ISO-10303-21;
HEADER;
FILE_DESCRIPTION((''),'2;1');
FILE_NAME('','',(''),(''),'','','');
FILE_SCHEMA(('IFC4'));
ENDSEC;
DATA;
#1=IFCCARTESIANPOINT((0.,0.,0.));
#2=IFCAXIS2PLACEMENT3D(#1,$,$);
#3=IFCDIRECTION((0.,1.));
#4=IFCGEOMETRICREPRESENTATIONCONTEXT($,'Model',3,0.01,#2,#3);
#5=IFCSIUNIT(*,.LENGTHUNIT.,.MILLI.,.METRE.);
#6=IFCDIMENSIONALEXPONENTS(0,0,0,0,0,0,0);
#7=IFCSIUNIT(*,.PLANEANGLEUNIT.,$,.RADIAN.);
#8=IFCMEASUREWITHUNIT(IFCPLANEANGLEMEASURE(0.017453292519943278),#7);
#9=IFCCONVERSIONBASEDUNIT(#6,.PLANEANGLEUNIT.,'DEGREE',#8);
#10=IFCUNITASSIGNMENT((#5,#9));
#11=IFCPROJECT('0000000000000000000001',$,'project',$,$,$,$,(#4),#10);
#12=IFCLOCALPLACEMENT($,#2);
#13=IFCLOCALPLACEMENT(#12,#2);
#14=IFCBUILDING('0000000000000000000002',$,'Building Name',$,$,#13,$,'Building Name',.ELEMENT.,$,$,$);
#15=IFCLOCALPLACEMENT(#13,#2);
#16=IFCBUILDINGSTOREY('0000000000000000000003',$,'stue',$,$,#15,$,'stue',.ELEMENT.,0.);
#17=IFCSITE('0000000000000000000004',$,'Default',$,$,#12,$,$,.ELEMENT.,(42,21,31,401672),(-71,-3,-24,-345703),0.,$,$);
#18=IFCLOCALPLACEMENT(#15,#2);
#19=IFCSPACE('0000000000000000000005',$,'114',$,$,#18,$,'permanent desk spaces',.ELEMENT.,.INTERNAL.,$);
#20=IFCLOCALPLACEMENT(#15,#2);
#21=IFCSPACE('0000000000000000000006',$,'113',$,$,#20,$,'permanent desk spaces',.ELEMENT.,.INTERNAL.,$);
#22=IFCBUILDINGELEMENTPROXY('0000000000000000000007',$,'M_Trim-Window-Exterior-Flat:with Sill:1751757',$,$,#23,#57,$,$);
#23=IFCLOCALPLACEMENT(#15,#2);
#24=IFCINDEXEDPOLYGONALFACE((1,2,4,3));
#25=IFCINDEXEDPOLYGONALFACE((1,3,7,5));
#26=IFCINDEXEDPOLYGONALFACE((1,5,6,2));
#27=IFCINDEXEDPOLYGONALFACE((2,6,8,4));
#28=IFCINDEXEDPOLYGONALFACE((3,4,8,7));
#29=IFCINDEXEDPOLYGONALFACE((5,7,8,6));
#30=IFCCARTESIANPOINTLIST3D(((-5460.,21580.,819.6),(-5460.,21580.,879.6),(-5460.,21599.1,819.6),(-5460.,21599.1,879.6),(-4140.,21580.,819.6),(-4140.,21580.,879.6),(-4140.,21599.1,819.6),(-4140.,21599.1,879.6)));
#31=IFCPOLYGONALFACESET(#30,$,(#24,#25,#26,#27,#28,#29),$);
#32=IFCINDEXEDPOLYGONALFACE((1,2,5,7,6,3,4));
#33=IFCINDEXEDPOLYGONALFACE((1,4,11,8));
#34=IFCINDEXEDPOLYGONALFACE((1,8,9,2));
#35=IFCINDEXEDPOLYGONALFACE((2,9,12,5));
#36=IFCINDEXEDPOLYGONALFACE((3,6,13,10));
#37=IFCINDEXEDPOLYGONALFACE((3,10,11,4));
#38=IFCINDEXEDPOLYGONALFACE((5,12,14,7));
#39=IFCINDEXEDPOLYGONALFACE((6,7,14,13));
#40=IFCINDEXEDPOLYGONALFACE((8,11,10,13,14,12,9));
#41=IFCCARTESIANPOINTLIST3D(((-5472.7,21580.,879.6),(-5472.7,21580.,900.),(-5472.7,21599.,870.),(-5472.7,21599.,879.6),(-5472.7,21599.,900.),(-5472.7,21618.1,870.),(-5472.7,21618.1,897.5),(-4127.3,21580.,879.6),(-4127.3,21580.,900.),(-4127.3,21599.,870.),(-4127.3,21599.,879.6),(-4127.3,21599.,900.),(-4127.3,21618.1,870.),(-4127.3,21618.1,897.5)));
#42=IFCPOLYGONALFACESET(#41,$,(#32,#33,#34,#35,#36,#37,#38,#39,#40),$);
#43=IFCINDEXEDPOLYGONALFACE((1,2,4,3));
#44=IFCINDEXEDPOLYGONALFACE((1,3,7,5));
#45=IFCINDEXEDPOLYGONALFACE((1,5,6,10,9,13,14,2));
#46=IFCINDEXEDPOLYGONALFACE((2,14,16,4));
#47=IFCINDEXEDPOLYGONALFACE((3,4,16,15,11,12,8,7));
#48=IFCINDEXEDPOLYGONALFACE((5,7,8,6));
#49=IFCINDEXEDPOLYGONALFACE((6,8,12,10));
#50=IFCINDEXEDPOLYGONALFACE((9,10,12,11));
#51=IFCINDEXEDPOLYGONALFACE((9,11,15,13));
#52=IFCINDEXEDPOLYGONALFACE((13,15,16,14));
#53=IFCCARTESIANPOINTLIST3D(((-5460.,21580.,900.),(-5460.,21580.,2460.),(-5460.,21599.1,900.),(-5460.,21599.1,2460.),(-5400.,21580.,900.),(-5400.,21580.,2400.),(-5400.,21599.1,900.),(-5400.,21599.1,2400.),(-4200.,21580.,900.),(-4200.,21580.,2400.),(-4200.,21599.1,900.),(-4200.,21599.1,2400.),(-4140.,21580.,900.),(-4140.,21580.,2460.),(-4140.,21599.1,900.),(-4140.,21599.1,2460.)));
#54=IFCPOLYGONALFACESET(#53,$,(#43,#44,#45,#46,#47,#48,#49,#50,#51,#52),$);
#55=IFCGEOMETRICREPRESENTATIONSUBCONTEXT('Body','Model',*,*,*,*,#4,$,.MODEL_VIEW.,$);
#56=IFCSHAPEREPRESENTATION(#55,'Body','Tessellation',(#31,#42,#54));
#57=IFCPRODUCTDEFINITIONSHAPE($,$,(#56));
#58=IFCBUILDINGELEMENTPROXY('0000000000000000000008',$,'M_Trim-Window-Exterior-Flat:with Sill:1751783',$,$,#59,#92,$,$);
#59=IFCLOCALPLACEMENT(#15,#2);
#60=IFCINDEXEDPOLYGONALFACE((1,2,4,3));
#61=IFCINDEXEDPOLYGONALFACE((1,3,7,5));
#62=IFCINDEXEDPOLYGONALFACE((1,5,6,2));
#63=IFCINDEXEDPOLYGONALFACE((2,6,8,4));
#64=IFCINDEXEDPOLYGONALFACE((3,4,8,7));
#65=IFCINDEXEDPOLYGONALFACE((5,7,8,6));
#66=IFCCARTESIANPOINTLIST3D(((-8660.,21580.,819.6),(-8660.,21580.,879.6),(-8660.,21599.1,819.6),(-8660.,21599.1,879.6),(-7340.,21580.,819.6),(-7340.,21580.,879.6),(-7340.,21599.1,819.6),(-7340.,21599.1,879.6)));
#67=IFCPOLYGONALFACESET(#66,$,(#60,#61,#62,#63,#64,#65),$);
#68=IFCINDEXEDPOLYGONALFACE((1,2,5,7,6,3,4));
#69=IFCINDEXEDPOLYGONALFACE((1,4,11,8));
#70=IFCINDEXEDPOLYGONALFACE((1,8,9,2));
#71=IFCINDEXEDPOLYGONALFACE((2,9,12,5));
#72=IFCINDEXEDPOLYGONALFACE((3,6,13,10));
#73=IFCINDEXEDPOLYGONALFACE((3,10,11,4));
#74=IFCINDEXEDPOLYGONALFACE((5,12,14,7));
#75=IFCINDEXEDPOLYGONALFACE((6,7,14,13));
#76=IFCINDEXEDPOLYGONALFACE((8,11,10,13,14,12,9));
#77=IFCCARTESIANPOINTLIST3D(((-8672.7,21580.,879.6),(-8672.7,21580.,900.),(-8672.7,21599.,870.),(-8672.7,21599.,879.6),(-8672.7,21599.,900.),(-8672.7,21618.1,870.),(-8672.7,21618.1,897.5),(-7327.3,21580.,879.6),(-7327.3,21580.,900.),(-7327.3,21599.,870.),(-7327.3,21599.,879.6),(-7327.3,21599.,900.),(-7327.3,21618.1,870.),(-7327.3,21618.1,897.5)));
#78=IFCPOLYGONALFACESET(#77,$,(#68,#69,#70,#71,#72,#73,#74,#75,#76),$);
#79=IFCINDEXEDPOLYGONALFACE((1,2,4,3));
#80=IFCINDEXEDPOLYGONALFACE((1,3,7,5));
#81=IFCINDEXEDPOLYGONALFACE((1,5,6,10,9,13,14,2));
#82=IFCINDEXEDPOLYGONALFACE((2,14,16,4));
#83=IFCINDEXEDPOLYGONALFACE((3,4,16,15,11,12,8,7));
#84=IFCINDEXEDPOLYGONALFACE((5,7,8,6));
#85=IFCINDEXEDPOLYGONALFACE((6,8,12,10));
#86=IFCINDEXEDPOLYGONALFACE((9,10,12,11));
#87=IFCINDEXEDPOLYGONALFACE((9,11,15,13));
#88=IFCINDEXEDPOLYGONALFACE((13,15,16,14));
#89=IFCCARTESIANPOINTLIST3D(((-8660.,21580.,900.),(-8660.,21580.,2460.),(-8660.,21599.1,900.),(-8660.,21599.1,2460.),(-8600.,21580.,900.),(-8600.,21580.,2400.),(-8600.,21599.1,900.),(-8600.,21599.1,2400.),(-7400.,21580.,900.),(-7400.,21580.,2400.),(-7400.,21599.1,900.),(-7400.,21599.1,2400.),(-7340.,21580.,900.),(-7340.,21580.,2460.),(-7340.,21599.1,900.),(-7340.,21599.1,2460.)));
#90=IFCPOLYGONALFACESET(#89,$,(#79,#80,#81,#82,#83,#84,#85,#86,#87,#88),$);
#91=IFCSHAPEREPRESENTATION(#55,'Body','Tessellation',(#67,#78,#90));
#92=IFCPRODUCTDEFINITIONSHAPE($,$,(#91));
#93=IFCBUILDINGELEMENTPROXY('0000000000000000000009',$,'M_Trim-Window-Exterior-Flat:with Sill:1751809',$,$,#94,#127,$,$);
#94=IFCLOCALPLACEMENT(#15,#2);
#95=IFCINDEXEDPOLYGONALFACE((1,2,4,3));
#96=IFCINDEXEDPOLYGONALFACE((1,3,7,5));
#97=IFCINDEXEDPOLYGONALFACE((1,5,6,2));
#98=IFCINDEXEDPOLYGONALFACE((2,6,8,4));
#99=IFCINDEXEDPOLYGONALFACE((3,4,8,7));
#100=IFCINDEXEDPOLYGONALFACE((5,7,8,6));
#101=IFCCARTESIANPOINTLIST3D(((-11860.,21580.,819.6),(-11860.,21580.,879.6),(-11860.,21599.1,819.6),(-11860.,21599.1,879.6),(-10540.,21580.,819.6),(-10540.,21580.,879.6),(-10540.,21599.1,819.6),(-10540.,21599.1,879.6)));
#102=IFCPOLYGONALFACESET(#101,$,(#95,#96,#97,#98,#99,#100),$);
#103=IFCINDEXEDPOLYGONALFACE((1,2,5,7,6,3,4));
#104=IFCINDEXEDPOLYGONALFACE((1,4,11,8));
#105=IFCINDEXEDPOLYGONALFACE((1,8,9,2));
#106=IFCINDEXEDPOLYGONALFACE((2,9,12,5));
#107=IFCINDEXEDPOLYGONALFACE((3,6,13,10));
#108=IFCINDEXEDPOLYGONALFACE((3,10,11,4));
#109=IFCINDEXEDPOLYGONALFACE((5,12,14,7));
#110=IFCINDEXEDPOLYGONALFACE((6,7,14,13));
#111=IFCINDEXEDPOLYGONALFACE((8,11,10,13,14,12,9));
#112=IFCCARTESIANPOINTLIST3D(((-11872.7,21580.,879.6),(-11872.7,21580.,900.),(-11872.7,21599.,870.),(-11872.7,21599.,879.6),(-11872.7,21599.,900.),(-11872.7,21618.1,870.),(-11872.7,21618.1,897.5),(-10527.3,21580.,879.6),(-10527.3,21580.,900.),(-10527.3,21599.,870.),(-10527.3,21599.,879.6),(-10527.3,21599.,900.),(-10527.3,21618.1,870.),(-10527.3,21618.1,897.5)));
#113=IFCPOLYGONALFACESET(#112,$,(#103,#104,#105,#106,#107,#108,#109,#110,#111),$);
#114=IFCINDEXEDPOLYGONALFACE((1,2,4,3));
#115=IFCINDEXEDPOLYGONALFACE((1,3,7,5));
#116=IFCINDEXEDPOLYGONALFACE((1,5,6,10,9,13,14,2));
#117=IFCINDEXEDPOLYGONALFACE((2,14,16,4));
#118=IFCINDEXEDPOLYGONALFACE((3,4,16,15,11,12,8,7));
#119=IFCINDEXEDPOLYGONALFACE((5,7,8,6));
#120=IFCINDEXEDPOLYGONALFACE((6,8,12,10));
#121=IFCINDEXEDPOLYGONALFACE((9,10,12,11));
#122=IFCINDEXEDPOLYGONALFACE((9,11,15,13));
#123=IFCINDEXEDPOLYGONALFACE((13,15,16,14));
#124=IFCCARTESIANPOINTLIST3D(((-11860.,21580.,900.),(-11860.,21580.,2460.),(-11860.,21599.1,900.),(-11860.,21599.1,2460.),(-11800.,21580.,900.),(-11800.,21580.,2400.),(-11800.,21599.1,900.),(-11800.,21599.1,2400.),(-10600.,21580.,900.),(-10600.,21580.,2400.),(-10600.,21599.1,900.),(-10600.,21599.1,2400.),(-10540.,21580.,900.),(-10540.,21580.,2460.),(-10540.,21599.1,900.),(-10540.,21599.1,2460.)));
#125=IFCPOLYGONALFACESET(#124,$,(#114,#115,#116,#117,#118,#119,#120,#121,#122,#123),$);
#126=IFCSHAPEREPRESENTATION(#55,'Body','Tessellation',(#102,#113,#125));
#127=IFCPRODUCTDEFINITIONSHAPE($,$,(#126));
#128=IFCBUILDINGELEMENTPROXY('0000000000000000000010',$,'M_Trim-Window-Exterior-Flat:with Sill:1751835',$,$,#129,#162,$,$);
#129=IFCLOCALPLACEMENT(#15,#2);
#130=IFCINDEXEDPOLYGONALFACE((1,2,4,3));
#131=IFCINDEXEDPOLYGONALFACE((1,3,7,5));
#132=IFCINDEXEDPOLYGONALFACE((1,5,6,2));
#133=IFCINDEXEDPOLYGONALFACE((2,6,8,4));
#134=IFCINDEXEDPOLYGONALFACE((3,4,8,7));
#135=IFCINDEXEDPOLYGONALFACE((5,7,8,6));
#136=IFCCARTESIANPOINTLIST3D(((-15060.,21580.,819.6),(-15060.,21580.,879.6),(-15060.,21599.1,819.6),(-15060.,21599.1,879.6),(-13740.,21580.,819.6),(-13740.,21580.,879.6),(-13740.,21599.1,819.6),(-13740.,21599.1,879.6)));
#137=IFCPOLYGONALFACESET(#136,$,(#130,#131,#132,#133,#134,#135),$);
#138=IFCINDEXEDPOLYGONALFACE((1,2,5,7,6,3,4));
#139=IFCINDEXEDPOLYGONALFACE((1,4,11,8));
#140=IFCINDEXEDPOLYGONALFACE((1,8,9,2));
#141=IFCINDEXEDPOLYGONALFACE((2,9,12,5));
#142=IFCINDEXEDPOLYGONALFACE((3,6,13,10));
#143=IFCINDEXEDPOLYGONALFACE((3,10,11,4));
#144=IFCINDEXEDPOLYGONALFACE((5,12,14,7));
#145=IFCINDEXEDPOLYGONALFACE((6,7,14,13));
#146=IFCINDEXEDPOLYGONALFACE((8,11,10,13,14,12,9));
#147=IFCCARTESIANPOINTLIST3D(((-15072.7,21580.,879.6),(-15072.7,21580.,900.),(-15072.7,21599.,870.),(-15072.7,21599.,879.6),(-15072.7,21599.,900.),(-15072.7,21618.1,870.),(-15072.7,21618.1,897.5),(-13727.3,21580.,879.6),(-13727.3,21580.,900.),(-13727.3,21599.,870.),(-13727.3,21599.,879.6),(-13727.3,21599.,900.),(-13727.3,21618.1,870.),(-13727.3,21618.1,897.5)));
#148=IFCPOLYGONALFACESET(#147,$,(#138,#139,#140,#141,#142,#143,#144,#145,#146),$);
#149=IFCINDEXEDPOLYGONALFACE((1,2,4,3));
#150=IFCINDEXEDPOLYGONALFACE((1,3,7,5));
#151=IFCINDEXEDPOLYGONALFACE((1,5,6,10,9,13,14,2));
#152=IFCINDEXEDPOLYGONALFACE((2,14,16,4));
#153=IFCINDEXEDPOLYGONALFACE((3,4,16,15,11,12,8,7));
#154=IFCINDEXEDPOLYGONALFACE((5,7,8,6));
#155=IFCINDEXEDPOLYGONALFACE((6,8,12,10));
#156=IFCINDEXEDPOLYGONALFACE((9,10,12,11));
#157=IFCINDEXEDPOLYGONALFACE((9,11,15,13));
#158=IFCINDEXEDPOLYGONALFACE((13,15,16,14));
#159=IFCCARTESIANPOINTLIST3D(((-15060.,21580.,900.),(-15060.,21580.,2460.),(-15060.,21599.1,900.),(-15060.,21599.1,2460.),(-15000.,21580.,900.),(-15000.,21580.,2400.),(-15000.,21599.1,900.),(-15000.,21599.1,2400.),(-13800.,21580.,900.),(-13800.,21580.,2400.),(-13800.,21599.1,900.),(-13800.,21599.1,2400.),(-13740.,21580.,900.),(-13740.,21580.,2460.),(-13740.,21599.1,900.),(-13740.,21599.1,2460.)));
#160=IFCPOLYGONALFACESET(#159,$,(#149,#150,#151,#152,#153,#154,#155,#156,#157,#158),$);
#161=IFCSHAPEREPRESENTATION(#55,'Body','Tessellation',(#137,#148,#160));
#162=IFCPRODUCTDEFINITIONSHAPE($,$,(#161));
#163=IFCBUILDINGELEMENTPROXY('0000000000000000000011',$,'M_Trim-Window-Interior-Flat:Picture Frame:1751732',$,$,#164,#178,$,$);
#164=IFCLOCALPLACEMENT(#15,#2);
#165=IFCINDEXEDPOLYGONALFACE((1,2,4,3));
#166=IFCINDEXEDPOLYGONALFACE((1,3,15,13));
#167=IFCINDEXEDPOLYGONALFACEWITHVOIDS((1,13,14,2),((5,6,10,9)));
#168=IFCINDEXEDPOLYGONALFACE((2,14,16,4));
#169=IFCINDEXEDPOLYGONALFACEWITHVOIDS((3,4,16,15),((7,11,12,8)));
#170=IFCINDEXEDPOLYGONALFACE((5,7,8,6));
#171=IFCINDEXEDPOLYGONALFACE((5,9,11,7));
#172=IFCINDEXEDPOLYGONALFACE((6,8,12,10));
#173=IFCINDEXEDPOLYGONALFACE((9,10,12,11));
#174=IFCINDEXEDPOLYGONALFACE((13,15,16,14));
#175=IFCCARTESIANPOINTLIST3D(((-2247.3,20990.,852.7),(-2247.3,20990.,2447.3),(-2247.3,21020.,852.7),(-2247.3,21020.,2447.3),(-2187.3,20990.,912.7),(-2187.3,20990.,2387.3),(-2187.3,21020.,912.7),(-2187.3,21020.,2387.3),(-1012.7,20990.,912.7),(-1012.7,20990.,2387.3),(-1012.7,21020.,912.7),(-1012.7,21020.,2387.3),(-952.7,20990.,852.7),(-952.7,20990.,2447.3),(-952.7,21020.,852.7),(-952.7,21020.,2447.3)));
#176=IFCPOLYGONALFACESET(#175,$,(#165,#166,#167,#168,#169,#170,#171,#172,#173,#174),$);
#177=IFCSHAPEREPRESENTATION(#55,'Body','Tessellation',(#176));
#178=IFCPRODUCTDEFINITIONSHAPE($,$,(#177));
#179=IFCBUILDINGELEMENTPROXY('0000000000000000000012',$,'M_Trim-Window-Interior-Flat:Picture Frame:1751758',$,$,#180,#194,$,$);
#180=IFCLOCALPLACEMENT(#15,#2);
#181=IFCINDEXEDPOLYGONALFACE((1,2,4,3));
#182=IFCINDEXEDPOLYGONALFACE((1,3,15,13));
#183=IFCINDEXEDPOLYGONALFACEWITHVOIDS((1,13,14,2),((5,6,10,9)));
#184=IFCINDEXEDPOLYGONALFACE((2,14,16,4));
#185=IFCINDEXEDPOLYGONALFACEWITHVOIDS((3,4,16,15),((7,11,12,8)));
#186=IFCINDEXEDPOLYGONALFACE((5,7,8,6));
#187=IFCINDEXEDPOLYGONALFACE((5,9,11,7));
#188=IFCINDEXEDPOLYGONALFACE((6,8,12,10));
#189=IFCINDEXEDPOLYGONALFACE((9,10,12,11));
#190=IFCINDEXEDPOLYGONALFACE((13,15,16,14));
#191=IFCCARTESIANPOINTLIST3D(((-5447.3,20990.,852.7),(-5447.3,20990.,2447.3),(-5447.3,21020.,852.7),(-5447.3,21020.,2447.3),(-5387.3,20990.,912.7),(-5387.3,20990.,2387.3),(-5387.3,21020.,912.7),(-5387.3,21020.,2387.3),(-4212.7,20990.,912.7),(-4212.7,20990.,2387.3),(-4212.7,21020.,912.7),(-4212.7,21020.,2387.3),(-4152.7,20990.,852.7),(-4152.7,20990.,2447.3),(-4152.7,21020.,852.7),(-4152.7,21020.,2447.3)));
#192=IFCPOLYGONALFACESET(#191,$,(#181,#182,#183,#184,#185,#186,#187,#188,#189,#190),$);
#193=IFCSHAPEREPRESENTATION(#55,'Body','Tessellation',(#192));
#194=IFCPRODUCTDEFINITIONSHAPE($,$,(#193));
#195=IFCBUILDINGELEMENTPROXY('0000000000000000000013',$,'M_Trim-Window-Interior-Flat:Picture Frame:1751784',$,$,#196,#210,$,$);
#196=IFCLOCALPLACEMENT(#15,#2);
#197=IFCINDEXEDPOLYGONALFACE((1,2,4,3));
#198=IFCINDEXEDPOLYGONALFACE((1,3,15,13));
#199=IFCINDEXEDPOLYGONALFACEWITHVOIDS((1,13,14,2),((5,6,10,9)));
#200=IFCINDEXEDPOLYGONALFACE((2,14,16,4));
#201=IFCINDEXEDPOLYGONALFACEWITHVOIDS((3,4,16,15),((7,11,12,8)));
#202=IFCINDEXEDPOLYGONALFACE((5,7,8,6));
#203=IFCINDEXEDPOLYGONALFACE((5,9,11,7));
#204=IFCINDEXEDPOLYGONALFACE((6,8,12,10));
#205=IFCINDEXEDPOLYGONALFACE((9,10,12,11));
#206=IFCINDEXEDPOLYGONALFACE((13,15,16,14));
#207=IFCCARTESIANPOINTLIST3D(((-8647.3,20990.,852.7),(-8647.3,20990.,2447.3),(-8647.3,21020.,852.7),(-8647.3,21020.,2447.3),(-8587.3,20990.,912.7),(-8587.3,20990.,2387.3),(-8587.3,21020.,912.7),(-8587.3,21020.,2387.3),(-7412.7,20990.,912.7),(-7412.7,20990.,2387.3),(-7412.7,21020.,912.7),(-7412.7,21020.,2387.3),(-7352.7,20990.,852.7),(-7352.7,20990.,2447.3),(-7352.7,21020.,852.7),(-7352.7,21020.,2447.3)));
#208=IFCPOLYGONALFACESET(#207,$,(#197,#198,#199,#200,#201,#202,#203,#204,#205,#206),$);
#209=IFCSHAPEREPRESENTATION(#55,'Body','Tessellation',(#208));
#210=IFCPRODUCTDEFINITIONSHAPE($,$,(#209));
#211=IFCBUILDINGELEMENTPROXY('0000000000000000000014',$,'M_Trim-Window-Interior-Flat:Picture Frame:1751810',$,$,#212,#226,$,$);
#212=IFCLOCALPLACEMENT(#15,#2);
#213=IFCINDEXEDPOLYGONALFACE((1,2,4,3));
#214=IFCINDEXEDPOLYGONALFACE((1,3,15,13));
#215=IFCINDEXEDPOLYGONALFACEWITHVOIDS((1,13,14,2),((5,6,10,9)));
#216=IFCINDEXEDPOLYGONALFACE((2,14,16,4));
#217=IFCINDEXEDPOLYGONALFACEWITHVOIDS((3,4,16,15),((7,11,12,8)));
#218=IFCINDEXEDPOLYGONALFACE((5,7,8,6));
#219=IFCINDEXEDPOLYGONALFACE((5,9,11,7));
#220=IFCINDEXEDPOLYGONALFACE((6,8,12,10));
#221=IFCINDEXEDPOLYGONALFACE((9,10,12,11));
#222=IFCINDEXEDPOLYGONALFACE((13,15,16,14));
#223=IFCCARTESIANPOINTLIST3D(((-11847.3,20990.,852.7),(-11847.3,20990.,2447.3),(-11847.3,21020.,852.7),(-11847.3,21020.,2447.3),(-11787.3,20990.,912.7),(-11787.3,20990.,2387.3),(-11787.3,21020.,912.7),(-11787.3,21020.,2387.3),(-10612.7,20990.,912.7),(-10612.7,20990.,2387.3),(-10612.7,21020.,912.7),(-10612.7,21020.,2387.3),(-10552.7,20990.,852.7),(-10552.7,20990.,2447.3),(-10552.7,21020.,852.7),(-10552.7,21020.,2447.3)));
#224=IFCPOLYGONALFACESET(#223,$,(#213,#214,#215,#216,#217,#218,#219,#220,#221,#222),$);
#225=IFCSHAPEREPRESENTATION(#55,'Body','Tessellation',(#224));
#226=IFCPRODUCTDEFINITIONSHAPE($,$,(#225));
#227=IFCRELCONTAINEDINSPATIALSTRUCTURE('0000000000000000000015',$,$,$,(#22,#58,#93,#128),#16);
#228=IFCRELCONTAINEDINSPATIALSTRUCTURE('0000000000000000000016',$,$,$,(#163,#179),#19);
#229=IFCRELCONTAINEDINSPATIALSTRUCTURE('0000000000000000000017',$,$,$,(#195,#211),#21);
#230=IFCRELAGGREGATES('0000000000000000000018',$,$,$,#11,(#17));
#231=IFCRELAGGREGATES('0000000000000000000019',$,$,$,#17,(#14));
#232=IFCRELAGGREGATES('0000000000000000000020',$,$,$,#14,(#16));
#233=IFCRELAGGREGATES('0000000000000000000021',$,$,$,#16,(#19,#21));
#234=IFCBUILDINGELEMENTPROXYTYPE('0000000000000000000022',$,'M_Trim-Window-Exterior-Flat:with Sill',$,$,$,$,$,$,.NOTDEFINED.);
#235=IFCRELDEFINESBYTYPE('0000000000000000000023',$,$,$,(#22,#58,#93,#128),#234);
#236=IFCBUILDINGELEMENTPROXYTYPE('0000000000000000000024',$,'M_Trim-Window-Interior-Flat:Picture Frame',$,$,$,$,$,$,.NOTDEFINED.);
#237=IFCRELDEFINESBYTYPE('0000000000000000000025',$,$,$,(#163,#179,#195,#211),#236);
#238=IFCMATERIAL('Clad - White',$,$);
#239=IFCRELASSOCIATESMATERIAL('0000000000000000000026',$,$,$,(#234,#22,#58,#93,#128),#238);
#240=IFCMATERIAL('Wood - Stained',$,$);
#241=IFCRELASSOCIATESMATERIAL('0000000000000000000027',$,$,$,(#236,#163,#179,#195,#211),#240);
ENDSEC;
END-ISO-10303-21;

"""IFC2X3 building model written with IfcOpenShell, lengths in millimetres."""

from ifc_helpers import new_model, entity, si_unit, converted_unit, direction, frame, frame_2d, origin, place, context, subcontext, project, spatial, polyline, rectangle, outline, extrude, source, transform, mapped, material, type_object, type_shapes, element, save


model = new_model("IFC2X3")

# Units and contexts
model_context = context("Model", 3, precision=0.01, world=origin(), true_north=direction((0.0, 1.0)))
body_context = subcontext(model_context, "Body", "Model", "MODEL_VIEW")
ifc_project = project(units=[si_unit("LENGTHUNIT", "METRE", prefix="MILLI"), converted_unit("PLANEANGLEUNIT", "DEGREE", entity("IfcPlaneAngleMeasure", 0.017453292519943278), si_unit("PLANEANGLEUNIT", "RADIAN"), dimensions=[0, 0, 0, 0, 0, 0, 0])], contexts=[model_context])

# Site, building, storey
site_placement = place(None, origin())
site = spatial("IfcSite", under=ifc_project, at=site_placement, Name="Default", CompositionType="ELEMENT", RefLatitude=(42, 21, 31, 401672), RefLongitude=(-71, -3, -24, -345703), RefElevation=0.0)
building_placement = place(site_placement, origin())
building = spatial("IfcBuilding", under=site, at=building_placement, Name="Building Name", LongName="Building Name", CompositionType="ELEMENT")
storey_placement = place(building_placement, origin())
storey = spatial("IfcBuildingStorey", under=building, at=storey_placement, Name="stue", LongName="stue", CompositionType="ELEMENT", Elevation=0.0)

# Building element proxies
ifc_material_1 = material(Name="Clad - White")
ifc_material_2 = material(Name="Wood - Stained")
building_element_proxy_type_1 = type_object("IfcBuildingElementProxyType", Name="M_Trim-Window-Exterior-Flat:with Sill", PredefinedType="NOTDEFINED", material=ifc_material_1)
shared_shape_1 = source(origin(), body_context, "Body", "SweptSolid", [
    extrude(rectangle(XDim=1320.0, YDim=60.0, at=frame_2d((0.0, 0.0), x_axis=(1.0, 0.0))), frame((0.0, -1550.4, 0.0), z_axis=(0.0, 0.0, 1.0), x_axis=(-1.0, 0.0, 0.0)), (0.0, 0.0, 1.0), 19.0),
    extrude(outline(polyline([(-19.0, -15.2), (0.0, -15.2), (0.0, -5.7), (19.0, -5.7), (19.0, 14.8), (0.0, 14.8), (-19.0, 12.3), (-19.0, -15.2)])), frame((-672.7, -1514.8, 19.0), z_axis=(1.0, 0.0, 0.0), x_axis=(0.0, 0.0, -1.0)), (0.0, 0.0, 1.0), 1345.4),
    extrude(outline(polyline([(-795.0, -660.0), (765.0, -660.0), (765.0, -600.0), (-735.0, -600.0), (-735.0, 600.0), (765.0, 600.0), (765.0, 660.0), (-795.0, 660.0), (-795.0, -660.0)])), frame((0.0, -735.0, 0.0), z_axis=(0.0, 0.0, 1.0), x_axis=(0.0, -1.0, 0.0)), (0.0, 0.0, 1.0), 19.0),
])
type_shapes(building_element_proxy_type_1, [shared_shape_1])
for number, where, z_axis, x_axis, name in (
    (1, (-4800.0, 21580.0, 2400.0), (0.0, 1.0, 0.0), (-1.0, 0.0, 0.0), "M_Trim-Window-Exterior-Flat:with Sill:1751757"),
    (2, (-8000.0, 21580.0, 2400.0), (0.0, 1.0, 0.0), (-1.0, 0.0, 0.0), "M_Trim-Window-Exterior-Flat:with Sill:1751783"),
    (3, (-11200.0, 21580.0, 2400.0), (0.0, 1.0, 0.0), (-1.0, 0.0, 0.0), "M_Trim-Window-Exterior-Flat:with Sill:1751809"),
    (4, (-14400.0, 21580.0, 2400.0), (0.0, 1.0, 0.0), (-1.0, 0.0, 0.0), "M_Trim-Window-Exterior-Flat:with Sill:1751835"),
):
    element("IfcBuildingElementProxy", number, at=place(storey_placement, frame(where, z_axis=z_axis, x_axis=x_axis)), inside=storey, type_object=building_element_proxy_type_1, material=ifc_material_1, Name=name, context=body_context, shape_type="MappedRepresentation", body=[
        mapped(shared_shape_1, transform((0.0, 0.0, 0.0), scale=1.0)),
    ])

# Shared definitions
space_1_placement = place(storey_placement, origin())
space_1 = spatial("IfcSpace", under=storey, at=space_1_placement, Name="114", LongName="permanent desk spaces", CompositionType="ELEMENT", InteriorOrExteriorSpace="INTERNAL")

# Building element proxies
building_element_proxy_type_2 = type_object("IfcBuildingElementProxyType", Name="M_Trim-Window-Interior-Flat:Picture Frame", PredefinedType="NOTDEFINED", material=ifc_material_2)
shared_shape_2 = source(origin(), body_context, "Body", "SweptSolid", [
    extrude(outline(polyline([(-647.3, -797.3), (647.3, -797.3), (647.3, 797.3), (-647.3, 797.3), (-647.3, -797.3)]), holes=[polyline([(-587.3, -737.3), (-587.3, 737.3), (587.3, 737.3), (587.3, -737.3), (-587.3, -737.3)])]), frame((0.0, -750.0, 0.0), z_axis=(0.0, 0.0, 1.0), x_axis=(-1.0, 0.0, 0.0)), (0.0, 0.0, 1.0), 30.0),
])
type_shapes(building_element_proxy_type_2, [shared_shape_2])
for number, where, z_axis, x_axis, name in (
    (5, (-1600.0, 21020.0, 2400.0), (0.0, -1.0, 0.0), (1.0, 0.0, 0.0), "M_Trim-Window-Interior-Flat:Picture Frame:1751732"),
    (6, (-4800.0, 21020.0, 2400.0), (0.0, -1.0, 0.0), (1.0, 0.0, 0.0), "M_Trim-Window-Interior-Flat:Picture Frame:1751758"),
):
    element("IfcBuildingElementProxy", number, at=place(space_1_placement, frame(where, z_axis=z_axis, x_axis=x_axis)), inside=space_1, type_object=building_element_proxy_type_2, material=ifc_material_2, Name=name, context=body_context, shape_type="MappedRepresentation", body=[
        mapped(shared_shape_2, transform((0.0, 0.0, 0.0), scale=1.0)),
    ])

# Shared definitions
space_2_placement = place(storey_placement, origin())
space_2 = spatial("IfcSpace", under=storey, at=space_2_placement, Name="113", LongName="permanent desk spaces", CompositionType="ELEMENT", InteriorOrExteriorSpace="INTERNAL")

# Building element proxies
for number, where, z_axis, x_axis, name in (
    (7, (-8000.0, 21020.0, 2400.0), (0.0, -1.0, 0.0), (1.0, 0.0, 0.0), "M_Trim-Window-Interior-Flat:Picture Frame:1751784"),
    (8, (-11200.0, 21020.0, 2400.0), (0.0, -1.0, 0.0), (1.0, 0.0, 0.0), "M_Trim-Window-Interior-Flat:Picture Frame:1751810"),
):
    element("IfcBuildingElementProxy", number, at=place(space_2_placement, frame(where, z_axis=z_axis, x_axis=x_axis)), inside=space_2, type_object=building_element_proxy_type_2, material=ifc_material_2, Name=name, context=body_context, shape_type="MappedRepresentation", body=[
        mapped(shared_shape_2, transform((0.0, 0.0, 0.0), scale=1.0)),
    ])

save(model, "model.ifc")
